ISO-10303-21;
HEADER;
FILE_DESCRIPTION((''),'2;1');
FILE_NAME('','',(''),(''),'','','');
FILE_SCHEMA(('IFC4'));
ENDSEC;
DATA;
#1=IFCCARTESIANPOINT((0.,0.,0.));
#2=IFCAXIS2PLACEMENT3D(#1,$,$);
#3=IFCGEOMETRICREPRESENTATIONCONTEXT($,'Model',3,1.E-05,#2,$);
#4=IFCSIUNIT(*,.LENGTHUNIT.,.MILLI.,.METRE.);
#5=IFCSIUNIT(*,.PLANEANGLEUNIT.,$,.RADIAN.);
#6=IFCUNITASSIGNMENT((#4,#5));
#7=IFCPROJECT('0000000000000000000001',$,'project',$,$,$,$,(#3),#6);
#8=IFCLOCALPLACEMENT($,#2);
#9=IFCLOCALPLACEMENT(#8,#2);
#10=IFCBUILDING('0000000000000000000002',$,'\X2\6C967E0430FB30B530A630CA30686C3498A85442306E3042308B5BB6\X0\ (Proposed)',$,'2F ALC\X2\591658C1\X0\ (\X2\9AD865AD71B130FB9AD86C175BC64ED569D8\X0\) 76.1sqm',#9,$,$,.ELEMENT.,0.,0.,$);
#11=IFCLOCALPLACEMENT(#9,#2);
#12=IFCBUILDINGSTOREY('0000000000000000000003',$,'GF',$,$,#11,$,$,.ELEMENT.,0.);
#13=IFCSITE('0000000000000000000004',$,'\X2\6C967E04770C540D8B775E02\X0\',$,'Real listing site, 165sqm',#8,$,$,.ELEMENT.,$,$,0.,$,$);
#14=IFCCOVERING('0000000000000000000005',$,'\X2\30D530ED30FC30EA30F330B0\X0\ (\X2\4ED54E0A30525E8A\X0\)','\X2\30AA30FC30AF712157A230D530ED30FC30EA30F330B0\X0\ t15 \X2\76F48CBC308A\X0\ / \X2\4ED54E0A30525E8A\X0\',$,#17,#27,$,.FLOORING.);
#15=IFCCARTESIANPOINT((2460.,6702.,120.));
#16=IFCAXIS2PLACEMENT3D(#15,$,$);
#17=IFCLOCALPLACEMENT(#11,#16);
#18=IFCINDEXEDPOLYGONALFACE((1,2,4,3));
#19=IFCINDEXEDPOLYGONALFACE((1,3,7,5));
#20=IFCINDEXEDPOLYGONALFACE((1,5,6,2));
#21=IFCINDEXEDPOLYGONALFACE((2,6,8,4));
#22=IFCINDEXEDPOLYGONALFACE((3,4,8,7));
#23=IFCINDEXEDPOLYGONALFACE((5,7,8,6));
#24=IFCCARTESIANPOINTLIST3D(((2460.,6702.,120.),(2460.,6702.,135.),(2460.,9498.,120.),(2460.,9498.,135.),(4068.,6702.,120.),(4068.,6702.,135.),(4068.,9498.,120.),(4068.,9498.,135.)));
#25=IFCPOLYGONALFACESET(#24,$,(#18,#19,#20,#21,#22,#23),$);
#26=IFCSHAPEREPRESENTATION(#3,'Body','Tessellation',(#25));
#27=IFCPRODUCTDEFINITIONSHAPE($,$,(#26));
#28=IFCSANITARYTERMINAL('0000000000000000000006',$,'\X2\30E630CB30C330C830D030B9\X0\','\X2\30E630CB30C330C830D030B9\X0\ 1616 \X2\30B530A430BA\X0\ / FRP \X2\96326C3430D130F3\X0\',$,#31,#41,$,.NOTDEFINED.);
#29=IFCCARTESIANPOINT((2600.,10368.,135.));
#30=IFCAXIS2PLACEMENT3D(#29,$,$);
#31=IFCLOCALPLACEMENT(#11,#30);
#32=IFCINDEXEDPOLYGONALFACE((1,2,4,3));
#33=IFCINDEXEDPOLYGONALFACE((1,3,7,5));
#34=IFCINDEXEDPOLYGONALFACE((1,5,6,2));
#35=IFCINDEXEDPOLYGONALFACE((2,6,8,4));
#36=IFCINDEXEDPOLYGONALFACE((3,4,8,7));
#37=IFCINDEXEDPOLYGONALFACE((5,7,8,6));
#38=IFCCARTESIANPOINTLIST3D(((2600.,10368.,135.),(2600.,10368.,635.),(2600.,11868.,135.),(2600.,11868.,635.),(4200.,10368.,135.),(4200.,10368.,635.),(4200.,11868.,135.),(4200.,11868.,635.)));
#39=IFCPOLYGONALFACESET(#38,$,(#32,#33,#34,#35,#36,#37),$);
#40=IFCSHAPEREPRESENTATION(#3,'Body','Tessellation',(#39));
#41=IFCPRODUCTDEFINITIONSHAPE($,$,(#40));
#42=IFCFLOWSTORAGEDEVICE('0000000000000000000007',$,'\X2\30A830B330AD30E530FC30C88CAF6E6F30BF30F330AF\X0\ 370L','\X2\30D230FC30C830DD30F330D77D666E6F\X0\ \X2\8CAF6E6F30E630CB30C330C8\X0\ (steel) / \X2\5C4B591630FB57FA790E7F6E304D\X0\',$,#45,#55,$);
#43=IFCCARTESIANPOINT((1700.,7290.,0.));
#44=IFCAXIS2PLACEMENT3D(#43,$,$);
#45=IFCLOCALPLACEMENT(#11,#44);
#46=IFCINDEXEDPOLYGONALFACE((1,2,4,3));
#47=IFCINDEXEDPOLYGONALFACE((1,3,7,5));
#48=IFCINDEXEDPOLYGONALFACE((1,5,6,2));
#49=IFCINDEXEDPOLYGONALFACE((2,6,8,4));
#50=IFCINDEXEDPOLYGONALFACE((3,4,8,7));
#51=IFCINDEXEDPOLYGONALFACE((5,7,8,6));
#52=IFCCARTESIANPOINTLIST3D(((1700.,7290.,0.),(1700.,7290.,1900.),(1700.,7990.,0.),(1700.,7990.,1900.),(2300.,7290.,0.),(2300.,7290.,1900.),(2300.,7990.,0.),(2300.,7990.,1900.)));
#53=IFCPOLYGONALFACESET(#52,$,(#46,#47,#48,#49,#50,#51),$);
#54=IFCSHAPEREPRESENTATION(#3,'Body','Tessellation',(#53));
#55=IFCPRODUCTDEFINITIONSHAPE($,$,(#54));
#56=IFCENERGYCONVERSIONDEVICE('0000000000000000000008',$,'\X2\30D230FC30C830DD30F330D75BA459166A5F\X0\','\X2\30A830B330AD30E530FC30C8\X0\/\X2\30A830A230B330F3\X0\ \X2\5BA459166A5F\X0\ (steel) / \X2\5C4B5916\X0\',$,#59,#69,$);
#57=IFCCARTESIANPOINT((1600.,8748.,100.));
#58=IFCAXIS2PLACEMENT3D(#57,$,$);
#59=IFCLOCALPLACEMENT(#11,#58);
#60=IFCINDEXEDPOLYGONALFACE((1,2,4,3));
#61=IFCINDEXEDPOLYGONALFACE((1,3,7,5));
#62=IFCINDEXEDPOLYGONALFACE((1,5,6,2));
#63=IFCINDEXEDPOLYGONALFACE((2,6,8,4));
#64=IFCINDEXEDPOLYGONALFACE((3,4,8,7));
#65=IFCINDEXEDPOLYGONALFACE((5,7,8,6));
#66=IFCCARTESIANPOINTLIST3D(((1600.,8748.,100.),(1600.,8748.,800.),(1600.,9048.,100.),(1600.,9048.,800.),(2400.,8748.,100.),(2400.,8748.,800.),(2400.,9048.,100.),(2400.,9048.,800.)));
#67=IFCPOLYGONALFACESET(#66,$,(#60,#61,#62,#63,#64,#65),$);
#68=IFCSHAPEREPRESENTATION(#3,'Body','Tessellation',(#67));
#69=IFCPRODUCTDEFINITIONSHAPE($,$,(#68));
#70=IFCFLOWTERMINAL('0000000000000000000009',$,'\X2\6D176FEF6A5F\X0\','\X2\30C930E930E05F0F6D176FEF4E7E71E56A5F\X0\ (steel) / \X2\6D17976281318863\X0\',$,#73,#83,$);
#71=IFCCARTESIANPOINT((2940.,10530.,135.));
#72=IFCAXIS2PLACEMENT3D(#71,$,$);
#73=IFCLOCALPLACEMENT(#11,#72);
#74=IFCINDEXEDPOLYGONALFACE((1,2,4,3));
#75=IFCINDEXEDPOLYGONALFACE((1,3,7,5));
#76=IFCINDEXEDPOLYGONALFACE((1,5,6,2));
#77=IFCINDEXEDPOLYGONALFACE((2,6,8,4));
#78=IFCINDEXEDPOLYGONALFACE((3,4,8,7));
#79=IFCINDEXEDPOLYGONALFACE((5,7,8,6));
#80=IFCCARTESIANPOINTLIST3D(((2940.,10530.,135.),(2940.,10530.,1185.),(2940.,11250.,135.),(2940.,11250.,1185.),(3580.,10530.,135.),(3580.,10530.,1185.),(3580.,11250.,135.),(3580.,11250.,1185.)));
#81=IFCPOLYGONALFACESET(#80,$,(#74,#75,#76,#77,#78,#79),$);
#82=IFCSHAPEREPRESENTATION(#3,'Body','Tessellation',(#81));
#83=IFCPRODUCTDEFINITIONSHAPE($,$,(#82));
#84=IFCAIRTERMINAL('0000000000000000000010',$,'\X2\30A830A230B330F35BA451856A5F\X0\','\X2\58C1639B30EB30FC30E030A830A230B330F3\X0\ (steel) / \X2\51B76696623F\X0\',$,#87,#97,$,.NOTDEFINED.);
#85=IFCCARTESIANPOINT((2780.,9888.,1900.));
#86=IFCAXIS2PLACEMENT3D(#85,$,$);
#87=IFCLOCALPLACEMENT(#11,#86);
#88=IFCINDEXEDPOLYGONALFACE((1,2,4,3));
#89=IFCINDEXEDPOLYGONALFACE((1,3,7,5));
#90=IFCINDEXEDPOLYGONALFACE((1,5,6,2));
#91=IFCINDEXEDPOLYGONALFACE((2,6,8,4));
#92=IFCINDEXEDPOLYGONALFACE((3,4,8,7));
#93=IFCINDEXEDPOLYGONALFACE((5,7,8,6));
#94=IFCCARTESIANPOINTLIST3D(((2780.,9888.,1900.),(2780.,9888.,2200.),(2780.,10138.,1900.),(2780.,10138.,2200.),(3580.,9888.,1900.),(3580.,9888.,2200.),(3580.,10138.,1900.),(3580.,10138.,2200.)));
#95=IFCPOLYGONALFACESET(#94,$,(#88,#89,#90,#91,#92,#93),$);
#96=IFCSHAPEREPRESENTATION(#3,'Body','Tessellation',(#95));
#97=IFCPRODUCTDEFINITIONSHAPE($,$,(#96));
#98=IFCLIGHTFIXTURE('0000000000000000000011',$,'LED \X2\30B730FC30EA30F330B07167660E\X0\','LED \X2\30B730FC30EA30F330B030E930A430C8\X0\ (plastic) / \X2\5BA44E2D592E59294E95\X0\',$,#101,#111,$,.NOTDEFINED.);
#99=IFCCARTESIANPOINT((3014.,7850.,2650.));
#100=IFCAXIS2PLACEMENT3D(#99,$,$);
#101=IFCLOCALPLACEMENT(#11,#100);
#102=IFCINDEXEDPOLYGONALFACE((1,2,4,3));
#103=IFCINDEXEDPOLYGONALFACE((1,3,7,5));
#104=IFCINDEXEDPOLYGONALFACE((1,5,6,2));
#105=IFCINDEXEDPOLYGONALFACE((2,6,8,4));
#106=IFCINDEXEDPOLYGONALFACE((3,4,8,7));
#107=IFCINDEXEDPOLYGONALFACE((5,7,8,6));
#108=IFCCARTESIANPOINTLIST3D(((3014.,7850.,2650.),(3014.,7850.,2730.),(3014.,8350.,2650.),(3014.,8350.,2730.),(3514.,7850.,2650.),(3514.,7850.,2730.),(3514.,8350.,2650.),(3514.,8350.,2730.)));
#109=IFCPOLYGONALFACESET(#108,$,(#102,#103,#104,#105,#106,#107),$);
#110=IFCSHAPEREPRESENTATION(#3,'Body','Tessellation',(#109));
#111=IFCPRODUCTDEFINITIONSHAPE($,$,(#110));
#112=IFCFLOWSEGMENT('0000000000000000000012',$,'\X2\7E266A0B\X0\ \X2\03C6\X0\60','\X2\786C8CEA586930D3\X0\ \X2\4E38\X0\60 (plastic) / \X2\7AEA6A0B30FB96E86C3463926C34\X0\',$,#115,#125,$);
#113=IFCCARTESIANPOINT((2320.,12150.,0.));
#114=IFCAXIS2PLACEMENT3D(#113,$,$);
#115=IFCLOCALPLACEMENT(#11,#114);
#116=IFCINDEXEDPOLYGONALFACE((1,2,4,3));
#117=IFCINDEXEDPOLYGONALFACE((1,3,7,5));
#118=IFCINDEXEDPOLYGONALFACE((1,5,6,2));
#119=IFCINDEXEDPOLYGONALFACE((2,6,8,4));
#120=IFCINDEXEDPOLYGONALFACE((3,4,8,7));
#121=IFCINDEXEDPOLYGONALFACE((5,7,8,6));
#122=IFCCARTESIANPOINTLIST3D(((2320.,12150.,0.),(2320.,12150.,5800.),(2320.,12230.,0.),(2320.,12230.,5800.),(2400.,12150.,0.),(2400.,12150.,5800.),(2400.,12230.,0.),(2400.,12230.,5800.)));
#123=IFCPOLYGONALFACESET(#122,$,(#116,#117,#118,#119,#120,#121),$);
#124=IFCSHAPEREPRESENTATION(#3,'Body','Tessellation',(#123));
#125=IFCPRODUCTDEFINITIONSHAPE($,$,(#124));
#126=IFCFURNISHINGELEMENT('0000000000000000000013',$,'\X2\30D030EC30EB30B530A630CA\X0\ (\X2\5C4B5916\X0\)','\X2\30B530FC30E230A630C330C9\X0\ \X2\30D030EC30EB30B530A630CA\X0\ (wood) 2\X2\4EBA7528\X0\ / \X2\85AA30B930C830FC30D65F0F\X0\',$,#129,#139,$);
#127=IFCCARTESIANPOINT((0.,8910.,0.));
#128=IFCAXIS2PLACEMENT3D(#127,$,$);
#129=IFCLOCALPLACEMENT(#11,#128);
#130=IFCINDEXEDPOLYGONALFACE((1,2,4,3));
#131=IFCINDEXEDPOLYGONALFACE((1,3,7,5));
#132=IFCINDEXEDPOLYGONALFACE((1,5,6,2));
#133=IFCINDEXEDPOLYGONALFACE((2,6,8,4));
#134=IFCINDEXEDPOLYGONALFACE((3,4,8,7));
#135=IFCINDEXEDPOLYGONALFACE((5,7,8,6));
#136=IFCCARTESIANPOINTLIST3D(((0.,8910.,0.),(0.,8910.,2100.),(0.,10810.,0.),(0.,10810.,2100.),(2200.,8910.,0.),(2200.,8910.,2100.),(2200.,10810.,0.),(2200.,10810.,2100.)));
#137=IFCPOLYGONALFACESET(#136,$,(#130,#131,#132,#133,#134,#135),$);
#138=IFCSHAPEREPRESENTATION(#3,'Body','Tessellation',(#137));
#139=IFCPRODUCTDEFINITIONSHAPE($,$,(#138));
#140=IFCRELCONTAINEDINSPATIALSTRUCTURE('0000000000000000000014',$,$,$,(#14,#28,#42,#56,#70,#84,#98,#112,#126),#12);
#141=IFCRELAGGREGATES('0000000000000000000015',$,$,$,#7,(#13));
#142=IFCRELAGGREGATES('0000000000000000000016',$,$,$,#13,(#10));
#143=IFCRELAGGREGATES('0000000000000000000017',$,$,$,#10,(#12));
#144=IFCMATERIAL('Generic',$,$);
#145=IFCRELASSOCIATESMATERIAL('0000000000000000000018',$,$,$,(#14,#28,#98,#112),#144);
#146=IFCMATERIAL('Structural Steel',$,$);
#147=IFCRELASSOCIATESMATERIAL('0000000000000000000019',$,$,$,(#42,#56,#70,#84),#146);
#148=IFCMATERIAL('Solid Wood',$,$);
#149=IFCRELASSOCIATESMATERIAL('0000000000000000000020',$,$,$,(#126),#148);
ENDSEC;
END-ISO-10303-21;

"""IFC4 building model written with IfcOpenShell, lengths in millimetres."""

from ifc_helpers import new_model, si_unit, frame, frame_2d, origin, place, context, project, spatial, rectangle, extrude, material, element, save


model = new_model("IFC4")

# Units and contexts
model_context = context("Model", 3, precision=1e-05, world=origin())
ifc_project = project(units=[si_unit("LENGTHUNIT", "METRE", prefix="MILLI"), si_unit("PLANEANGLEUNIT", "RADIAN")], contexts=[model_context])

# Site, building, storey
site_placement = place(None, origin())
site = spatial("IfcSite", under=ifc_project, at=site_placement, Name="沖縄県名護市", ObjectType="Real listing site, 165sqm", CompositionType="ELEMENT", RefElevation=0.0)
building_placement = place(site_placement, origin())
building = spatial("IfcBuilding", under=site, at=building_placement, Name="沖縄・サウナと水風呂のある家 (Proposed)", ObjectType="2F ALC外壁 (高断熱・高気密仕様) 76.1sqm", CompositionType="ELEMENT", ElevationOfRefHeight=0.0, ElevationOfTerrain=0.0)
storey_placement = place(building_placement, origin())
storey = spatial("IfcBuildingStorey", under=building, at=storey_placement, Name="GF", CompositionType="ELEMENT", Elevation=0.0)

# Shared definitions
ifc_material_1 = material(Name="Solid Wood")

# Covering
ifc_material_2 = material(Name="Generic")
covering_1_placement = place(storey_placement, frame((2460.0, 6702.0, 120.0)))
element("IfcCovering", 1, at=covering_1_placement, inside=storey, material=ifc_material_2, Name="フローリング (仕上げ床)", Description="オーク無垢フローリング t15 直貼り / 仕上げ床", PredefinedType="FLOORING", context=model_context, shape_type="SweptSolid", body=[
    extrude(rectangle(XDim=1608.0, YDim=2796.0, at=frame_2d((804.0, 1398.0))), frame((2460.0, 6702.0, 120.0)), (0.0, 0.0, 1.0), 15.0),
])

# Sanitary terminal
sanitary_terminal_placement = place(storey_placement, frame((2600.0, 10368.0, 135.0)))
element("IfcSanitaryTerminal", 2, at=sanitary_terminal_placement, inside=storey, material=ifc_material_2, Name="ユニットバス", Description="ユニットバス 1616 サイズ / FRP 防水パン", PredefinedType="NOTDEFINED", context=model_context, shape_type="SweptSolid", body=[
    extrude(rectangle(XDim=1600.0, YDim=1500.0, at=frame_2d((800.0, 750.0))), frame((2600.0, 10368.0, 135.0)), (0.0, 0.0, 1.0), 500.0),
])

# Flow storage device
ifc_material_3 = material(Name="Structural Steel")
flow_storage_device_placement = place(storey_placement, frame((1700.0, 7290.0, 0.0)))
element("IfcFlowStorageDevice", 3, at=flow_storage_device_placement, inside=storey, material=ifc_material_3, Name="エコキュート貯湯タンク 370L", Description="ヒートポンプ給湯 貯湯ユニット (steel) / 屋外・基礎置き", context=model_context, shape_type="SweptSolid", body=[
    extrude(rectangle(XDim=600.0, YDim=700.0, at=frame_2d((300.0, 350.0))), frame((1700.0, 7290.0, 0.0)), (0.0, 0.0, 1.0), 1900.0),
])

# Energy conversion device
energy_conversion_device_placement = place(storey_placement, frame((1600.0, 8748.0, 100.0)))
element("IfcEnergyConversionDevice", 4, at=energy_conversion_device_placement, inside=storey, material=ifc_material_3, Name="ヒートポンプ室外機", Description="エコキュート/エアコン 室外機 (steel) / 屋外", context=model_context, shape_type="SweptSolid", body=[
    extrude(rectangle(XDim=800.0, YDim=300.0, at=frame_2d((400.0, 150.0))), frame((1600.0, 8748.0, 100.0)), (0.0, 0.0, 1.0), 700.0),
])

# Flow terminal
flow_terminal_placement = place(storey_placement, frame((2940.0, 10530.0, 135.0)))
element("IfcFlowTerminal", 5, at=flow_terminal_placement, inside=storey, material=ifc_material_3, Name="洗濯機", Description="ドラム式洗濯乾燥機 (steel) / 洗面脱衣", context=model_context, shape_type="SweptSolid", body=[
    extrude(rectangle(XDim=640.0, YDim=720.0, at=frame_2d((320.0, 360.0))), frame((2940.0, 10530.0, 135.0)), (0.0, 0.0, 1.0), 1050.0),
])

# Air terminal
air_terminal_placement = place(storey_placement, frame((2780.0, 9888.0, 1900.0)))
element("IfcAirTerminal", 6, at=air_terminal_placement, inside=storey, material=ifc_material_3, Name="エアコン室内機", Description="壁掛ルームエアコン (steel) / 冷暖房", PredefinedType="NOTDEFINED", context=model_context, shape_type="SweptSolid", body=[
    extrude(rectangle(XDim=800.0, YDim=250.0, at=frame_2d((400.0, 125.0))), frame((2780.0, 9888.0, 1900.0)), (0.0, 0.0, 1.0), 300.0),
])

# Light fixture
light_fixture_placement = place(storey_placement, frame((3014.0, 7850.0, 2650.0)))
element("IfcLightFixture", 7, at=light_fixture_placement, inside=storey, material=ifc_material_2, Name="LED シーリング照明", Description="LED シーリングライト (plastic) / 室中央天井", PredefinedType="NOTDEFINED", context=model_context, shape_type="SweptSolid", body=[
    extrude(rectangle(XDim=500.0, YDim=500.0, at=frame_2d((250.0, 250.0))), frame((3014.0, 7850.0, 2650.0)), (0.0, 0.0, 1.0), 80.0),
])

# Flow segment
flow_segment_placement = place(storey_placement, frame((2320.0, 12150.0, 0.0)))
element("IfcFlowSegment", 8, at=flow_segment_placement, inside=storey, material=ifc_material_2, Name="縦樋 φ60", Description="硬質塩ビ 丸60 (plastic) / 竪樋・雨水排水", context=model_context, shape_type="SweptSolid", body=[
    extrude(rectangle(XDim=80.0, YDim=80.0, at=frame_2d((40.0, 40.0))), frame((2320.0, 12150.0, 0.0)), (0.0, 0.0, 1.0), 5800.0),
])

# Furnishing element
furnishing_placement = place(storey_placement, frame((0.0, 8910.0, 0.0)))
element("IfcFurnishingElement", 9, at=furnishing_placement, inside=storey, material=ifc_material_1, Name="バレルサウナ (屋外)", Description="サーモウッド バレルサウナ (wood) 2人用 / 薪ストーブ式", context=model_context, shape_type="SweptSolid", body=[
    extrude(rectangle(XDim=2200.0, YDim=1900.0, at=frame_2d((1100.0, 950.0))), frame((0.0, 8910.0, 0.0)), (0.0, 0.0, 1.0), 2100.0),
])

save(model, "model.ifc")
